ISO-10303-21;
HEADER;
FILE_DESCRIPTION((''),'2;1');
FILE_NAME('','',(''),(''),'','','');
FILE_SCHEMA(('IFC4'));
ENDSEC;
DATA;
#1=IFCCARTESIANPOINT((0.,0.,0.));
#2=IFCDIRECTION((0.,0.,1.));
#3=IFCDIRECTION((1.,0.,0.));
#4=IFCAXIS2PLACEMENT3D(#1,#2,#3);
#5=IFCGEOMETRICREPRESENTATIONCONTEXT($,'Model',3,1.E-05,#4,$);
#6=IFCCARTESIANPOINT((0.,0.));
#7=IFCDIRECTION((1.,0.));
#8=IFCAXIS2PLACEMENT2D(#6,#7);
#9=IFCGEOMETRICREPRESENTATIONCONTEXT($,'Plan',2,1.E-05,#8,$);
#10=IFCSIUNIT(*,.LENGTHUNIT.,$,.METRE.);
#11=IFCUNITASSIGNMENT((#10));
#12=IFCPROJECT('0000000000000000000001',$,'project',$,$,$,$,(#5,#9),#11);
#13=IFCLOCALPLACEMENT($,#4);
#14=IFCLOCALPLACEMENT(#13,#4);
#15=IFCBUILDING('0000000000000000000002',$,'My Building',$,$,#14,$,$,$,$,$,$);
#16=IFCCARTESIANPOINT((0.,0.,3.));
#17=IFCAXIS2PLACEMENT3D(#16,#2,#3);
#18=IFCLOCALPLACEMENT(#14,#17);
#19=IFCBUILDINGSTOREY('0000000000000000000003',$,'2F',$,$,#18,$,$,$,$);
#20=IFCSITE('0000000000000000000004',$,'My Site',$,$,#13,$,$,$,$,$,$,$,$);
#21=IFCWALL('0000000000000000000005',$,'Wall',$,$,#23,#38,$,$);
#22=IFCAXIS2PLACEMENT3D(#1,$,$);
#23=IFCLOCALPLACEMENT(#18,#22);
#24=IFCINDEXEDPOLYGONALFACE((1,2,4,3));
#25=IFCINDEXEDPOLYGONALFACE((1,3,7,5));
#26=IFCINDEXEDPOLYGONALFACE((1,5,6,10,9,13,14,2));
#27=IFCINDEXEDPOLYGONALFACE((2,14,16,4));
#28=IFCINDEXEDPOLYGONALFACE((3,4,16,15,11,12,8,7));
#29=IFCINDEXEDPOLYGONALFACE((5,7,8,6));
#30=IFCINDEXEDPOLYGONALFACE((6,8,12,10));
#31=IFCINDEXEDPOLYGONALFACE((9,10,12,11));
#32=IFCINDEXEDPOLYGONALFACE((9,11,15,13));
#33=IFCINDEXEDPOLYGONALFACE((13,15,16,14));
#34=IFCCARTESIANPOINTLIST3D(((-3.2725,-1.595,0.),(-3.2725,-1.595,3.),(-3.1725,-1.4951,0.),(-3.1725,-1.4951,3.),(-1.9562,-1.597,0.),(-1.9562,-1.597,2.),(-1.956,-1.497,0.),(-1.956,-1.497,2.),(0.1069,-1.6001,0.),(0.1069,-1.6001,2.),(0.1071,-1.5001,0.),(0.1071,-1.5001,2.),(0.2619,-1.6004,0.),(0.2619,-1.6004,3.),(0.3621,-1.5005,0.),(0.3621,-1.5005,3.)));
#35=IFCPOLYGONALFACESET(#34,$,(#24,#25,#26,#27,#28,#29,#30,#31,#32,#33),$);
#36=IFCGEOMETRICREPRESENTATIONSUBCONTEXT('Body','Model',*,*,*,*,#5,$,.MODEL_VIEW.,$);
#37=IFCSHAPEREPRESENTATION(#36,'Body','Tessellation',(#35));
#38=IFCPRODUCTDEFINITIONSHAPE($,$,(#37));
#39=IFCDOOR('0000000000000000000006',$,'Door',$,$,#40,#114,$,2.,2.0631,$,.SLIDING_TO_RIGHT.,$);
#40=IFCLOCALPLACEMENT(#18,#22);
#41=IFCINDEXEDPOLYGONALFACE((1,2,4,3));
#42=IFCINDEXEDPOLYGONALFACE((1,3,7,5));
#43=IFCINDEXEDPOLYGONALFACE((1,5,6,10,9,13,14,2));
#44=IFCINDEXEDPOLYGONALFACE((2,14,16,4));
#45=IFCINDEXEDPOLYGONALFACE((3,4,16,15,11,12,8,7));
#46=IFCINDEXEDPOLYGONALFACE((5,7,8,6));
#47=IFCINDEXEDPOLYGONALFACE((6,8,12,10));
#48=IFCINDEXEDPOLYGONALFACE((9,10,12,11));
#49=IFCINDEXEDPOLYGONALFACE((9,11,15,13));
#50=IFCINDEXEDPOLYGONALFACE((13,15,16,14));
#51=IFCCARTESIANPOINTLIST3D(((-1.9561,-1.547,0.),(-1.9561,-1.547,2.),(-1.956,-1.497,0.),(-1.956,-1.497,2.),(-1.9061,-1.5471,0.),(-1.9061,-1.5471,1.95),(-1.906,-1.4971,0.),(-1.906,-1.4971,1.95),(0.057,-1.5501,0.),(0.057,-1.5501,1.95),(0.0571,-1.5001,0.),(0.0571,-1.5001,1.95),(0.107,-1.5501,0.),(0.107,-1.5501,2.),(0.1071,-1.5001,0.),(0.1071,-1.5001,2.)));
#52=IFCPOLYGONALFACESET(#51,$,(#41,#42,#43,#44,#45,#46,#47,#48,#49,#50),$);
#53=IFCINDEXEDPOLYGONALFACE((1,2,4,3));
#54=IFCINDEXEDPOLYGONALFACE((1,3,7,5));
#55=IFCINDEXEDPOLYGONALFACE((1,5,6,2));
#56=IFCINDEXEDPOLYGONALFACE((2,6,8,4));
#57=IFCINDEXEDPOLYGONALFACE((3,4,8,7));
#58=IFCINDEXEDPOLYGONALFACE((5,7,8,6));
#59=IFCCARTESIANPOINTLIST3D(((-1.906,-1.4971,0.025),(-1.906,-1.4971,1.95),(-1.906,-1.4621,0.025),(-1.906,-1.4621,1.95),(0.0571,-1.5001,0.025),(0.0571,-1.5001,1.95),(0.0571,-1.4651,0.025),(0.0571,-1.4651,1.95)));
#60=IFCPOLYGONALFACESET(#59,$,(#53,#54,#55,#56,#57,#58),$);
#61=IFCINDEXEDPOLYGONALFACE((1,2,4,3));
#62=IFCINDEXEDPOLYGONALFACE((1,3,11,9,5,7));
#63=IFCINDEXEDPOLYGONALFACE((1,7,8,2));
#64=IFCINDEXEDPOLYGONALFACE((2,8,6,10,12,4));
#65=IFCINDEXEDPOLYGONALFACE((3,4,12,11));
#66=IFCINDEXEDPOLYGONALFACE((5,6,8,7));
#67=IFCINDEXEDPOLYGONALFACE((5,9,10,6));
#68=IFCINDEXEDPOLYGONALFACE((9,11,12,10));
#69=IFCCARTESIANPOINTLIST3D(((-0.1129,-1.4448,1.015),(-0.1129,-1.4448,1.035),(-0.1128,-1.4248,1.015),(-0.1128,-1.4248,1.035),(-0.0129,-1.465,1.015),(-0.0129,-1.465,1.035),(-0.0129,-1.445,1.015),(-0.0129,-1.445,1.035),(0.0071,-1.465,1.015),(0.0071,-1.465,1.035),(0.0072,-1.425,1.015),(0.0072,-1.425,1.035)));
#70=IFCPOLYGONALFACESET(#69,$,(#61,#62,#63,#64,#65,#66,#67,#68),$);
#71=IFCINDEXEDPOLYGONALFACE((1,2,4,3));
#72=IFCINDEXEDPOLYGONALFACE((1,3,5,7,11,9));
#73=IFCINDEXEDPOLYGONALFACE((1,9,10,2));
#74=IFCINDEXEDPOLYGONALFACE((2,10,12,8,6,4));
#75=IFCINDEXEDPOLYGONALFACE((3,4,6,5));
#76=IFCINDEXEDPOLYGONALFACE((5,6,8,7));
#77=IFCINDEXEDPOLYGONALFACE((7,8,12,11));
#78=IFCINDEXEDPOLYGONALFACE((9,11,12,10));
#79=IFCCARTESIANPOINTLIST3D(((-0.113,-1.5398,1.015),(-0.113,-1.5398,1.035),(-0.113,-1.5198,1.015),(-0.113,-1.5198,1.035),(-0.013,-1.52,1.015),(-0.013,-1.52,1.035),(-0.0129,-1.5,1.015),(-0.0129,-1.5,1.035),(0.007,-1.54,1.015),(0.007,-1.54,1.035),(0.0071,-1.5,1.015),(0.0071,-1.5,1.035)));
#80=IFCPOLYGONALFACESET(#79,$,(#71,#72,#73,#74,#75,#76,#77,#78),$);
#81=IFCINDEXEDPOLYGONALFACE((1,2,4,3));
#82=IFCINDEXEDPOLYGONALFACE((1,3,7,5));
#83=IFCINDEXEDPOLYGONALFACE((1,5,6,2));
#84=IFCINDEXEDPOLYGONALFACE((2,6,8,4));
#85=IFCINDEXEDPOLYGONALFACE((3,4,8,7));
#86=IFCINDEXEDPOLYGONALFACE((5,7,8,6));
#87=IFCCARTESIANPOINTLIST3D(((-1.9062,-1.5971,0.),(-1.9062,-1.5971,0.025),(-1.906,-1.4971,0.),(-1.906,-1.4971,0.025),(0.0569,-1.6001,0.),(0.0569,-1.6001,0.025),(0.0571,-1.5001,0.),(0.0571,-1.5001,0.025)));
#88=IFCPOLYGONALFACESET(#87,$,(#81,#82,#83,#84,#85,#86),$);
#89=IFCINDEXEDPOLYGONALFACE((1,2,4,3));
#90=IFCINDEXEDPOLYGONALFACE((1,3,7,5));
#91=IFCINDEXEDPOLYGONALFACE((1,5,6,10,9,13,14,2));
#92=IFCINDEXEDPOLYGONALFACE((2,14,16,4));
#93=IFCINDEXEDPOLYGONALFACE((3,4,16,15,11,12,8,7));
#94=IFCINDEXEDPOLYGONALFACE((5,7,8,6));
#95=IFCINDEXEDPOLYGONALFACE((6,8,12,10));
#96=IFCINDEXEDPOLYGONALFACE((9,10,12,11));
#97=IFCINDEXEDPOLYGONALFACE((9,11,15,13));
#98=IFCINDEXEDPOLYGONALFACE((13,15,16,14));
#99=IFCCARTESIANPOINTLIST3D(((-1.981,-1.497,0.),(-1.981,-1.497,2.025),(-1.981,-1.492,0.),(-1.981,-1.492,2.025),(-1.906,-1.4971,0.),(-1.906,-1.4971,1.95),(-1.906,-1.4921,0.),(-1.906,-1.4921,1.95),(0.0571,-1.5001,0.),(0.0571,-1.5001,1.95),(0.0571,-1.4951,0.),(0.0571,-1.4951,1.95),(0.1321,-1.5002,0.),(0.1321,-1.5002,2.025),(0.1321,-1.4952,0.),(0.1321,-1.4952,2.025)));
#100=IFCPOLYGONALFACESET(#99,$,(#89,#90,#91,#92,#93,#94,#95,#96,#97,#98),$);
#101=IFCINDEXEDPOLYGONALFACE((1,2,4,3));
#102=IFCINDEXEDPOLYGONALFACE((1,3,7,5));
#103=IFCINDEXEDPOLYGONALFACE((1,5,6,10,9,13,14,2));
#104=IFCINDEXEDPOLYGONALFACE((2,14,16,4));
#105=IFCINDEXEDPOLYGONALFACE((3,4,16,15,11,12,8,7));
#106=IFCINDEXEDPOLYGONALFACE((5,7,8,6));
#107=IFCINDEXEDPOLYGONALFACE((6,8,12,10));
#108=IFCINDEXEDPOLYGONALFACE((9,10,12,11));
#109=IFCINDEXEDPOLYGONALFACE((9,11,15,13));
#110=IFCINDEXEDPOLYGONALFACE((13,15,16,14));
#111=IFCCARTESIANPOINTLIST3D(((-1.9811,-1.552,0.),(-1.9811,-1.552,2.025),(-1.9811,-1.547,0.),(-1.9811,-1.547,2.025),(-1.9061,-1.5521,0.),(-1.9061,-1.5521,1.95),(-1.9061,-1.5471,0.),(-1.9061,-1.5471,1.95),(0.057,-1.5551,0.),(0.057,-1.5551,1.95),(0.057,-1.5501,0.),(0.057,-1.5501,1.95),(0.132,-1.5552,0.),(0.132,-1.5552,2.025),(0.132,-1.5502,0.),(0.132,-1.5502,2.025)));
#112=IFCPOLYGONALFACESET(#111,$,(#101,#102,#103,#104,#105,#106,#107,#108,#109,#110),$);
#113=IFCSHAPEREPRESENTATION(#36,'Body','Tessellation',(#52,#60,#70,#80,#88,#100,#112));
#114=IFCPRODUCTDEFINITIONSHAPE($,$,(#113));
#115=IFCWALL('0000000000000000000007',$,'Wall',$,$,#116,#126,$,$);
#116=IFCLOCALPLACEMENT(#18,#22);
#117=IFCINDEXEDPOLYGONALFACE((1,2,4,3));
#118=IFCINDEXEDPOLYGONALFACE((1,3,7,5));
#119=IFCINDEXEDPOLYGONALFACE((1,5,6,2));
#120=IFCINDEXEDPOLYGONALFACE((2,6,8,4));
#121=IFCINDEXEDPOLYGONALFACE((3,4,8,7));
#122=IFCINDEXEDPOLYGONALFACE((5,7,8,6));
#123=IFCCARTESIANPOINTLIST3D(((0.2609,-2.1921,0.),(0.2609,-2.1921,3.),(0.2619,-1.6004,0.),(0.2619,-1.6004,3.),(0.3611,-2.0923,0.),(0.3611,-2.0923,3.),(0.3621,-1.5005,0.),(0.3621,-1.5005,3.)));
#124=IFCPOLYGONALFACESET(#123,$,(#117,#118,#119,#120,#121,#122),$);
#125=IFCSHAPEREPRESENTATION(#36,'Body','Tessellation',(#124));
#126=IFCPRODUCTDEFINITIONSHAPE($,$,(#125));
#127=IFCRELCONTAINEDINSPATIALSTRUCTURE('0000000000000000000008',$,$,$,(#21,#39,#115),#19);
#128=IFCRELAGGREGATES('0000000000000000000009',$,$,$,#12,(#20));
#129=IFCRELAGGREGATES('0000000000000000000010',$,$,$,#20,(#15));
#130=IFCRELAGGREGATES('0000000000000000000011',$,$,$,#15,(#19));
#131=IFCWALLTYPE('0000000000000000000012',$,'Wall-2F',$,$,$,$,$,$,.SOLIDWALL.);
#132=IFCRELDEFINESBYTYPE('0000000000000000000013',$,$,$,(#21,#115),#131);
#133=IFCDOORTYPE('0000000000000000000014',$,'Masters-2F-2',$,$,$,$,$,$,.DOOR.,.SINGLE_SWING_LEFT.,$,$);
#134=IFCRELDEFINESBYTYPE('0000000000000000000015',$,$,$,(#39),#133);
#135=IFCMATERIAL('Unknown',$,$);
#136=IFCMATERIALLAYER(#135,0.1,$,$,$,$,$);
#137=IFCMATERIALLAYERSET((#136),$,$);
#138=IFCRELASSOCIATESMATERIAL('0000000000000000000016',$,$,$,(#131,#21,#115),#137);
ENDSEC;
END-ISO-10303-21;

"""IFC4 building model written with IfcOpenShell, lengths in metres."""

from ifc_helpers import new_model, entity, si_unit, frame, origin_with_axes, origin_2d_with_axis, place, context, subcontext, project, spatial, line, indexed_curve, outline, extrude, shape, source, transform, mapped, material, layer, layer_set, layer_usage, type_object, type_shapes, element, fill, save


model = new_model("IFC4")

# Units and contexts
model_context = context("Model", 3, precision=1e-05, world=origin_with_axes())
plan_context = context("Plan", 2, precision=1e-05, world=origin_2d_with_axis())
body_context_1 = subcontext(model_context, "Body", "Model", "MODEL_VIEW")
body_context_2 = subcontext(plan_context, "Body", "Plan", "PLAN_VIEW")
ifc_project = project(units=[si_unit("LENGTHUNIT", "METRE")], contexts=[model_context, plan_context])

# Site, building, storey
site_placement = place(None, origin_with_axes())
site = spatial("IfcSite", under=ifc_project, at=site_placement, Name="My Site")
building_placement = place(site_placement, origin_with_axes())
building = spatial("IfcBuilding", under=site, at=building_placement, Name="My Building")
storey_placement = place(building_placement, frame((0.0, 0.0, 3.0), z_axis=(0.0, 0.0, 1.0), x_axis=(1.0, 0.0, 0.0)))
storey = spatial("IfcBuildingStorey", under=building, at=storey_placement, Name="2F")

# Shared definitions
ifc_material = material(Name="Unknown")

# Wall, opening, door
ifc_layer_1 = layer(ifc_material, 0.1)
ifc_layer_set_1 = layer_set([ifc_layer_1])
ifc_layer_usage_1 = layer_usage(ifc_layer_set_1, "AXIS2", "POSITIVE", 0.0)
wall_type = type_object("IfcWallType", Name="Wall-2F", PredefinedType="SOLIDWALL", material=ifc_layer_set_1)
wall_1_placement = place(storey_placement, frame((-3.2725, -1.595, 0.0), z_axis=(0.0, 0.0, 1.0), x_axis=(0.999999, -0.001525, 0.0)))
wall_1 = element("IfcWall", 1, at=wall_1_placement, inside=storey, type_object=wall_type, material=ifc_layer_usage_1, Name="Wall", context=body_context_1, shape_type="SweptSolid", body=[
    extrude(outline(indexed_curve([(0.0, 0.0), (0.0998, 0.1), (3.6345, 0.1), (3.5345, 0.0)], segments=[line(1, 2, 3, 4, 1)])), origin_with_axes(), (0.0, 0.0, 1.0), 3.0),
])
shared_shape_1 = source(origin_with_axes(), body_context_1, "Body", "SweptSolid", [
    extrude(outline(indexed_curve([(0.0, 0.0), (2.0631, 0.0), (2.0631, 2.0), (0.0, 2.0)], segments=[line(1, 2, 3, 4, 1)])), frame((0.0, -0.6, 0.0), z_axis=(0.0, -1.0, 0.0), x_axis=(1.0, 0.0, 0.0)), (0.0, 0.0, -1.0), 1.2),
])
opening_1_placement = place(wall_1_placement, frame((3.3794, 0.1, 0.0), z_axis=(0.0, 0.0, 1.0), x_axis=(-1.0, 0.0, 0.0)))
opening_1 = element("IfcOpeningElement", 2, at=opening_1_placement, cuts=wall_1, PredefinedType="OPENING", context=body_context_1, shape_type="MappedRepresentation", body=[
    mapped(shared_shape_1, transform((0.0, 0.0, 0.0), x_axis=(1.0, 0.0, 0.0), y_axis=(0.0, 1.0, 0.0), z_axis=(0.0, 0.0, 1.0), scale=1.0)),
])
door_type_1 = type_object("IfcDoorType", Name="Masters-2F-2", OperationType="SINGLE_SWING_LEFT", PredefinedType="DOOR")
shared_shape_2 = source(origin_with_axes(), body_context_1, "Body", "SweptSolid", [
    extrude(outline(indexed_curve([(0.0, 0.0), (0.0, 2.0), (2.0631, 2.0), (2.0631, 0.0), (2.0131, 0.0), (2.0131, 1.95), (0.05, 1.95), (0.05, 0.0)], segments=[line(1, 2, 3, 4, 5, 6, 7, 8, 1)])), frame((0.0, 0.0, 0.0), z_axis=(0.0, -1.0, 0.0), x_axis=(1.0, 0.0, 0.0)), (0.0, 0.0, -1.0), 0.05),
    extrude(outline(indexed_curve([(0.0, 0.0), (1.9631, 0.0), (1.9631, 0.035), (0.0, 0.035)], segments=[line(1, 2, 3, 4, 1)])), frame((0.05, -0.035, 0.025), z_axis=(0.0, 0.0, 1.0), x_axis=(1.0, 0.0, 0.0)), (0.0, 0.0, 1.0), 1.925),
    extrude(outline(indexed_curve([(0.0, 0.0), (0.0, -0.04), (0.12, -0.04), (0.12, -0.02), (0.02, -0.02), (0.02, 0.0)], segments=[line(1, 2, 3, 4, 5, 6, 1)])), frame((0.1, -0.035, 1.015), z_axis=(0.0, 0.0, 1.0), x_axis=(1.0, 0.0, 0.0)), (0.0, 0.0, 1.0), 0.02),
    extrude(outline(indexed_curve([(0.0, 0.0), (0.0, 0.04), (0.12, 0.04), (0.12, 0.02), (0.02, 0.02), (0.02, 0.0)], segments=[line(1, 2, 3, 4, 5, 6, 1)])), frame((0.1, 0.0, 1.015), z_axis=(0.0, 0.0, 1.0), x_axis=(1.0, 0.0, 0.0)), (0.0, 0.0, 1.0), 0.02),
    extrude(outline(indexed_curve([(0.0, 0.0), (1.9631, 0.0), (1.9631, 0.1), (0.0, 0.1)], segments=[line(1, 2, 3, 4, 1)])), frame((0.05, 0.0, 0.0), z_axis=(0.0, 0.0, 1.0), x_axis=(1.0, 0.0, 0.0)), (0.0, 0.0, 1.0), 0.025),
    extrude(outline(indexed_curve([(0.0, 0.0), (0.0, 2.025), (2.1131, 2.025), (2.1131, 0.0), (2.0381, 0.0), (2.0381, 1.95), (0.075, 1.95), (0.075, 0.0)], segments=[line(1, 2, 3, 4, 5, 6, 7, 8, 1)])), frame((-0.025, -0.005, 0.0), z_axis=(0.0, -1.0, 0.0), x_axis=(1.0, 0.0, 0.0)), (0.0, 0.0, -1.0), 0.005),
    extrude(outline(indexed_curve([(0.0, 0.0), (0.0, 2.025), (2.1131, 2.025), (2.1131, 0.0), (2.0381, 0.0), (2.0381, 1.95), (0.075, 1.95), (0.075, 0.0)], segments=[line(1, 2, 3, 4, 5, 6, 7, 8, 1)])), frame((-0.025, 0.05, 0.0), z_axis=(0.0, -1.0, 0.0), x_axis=(1.0, 0.0, 0.0)), (0.0, 0.0, -1.0), 0.005),
])
shared_shape_3 = source(origin_with_axes(), body_context_2, "Body", "Curve2D", [
    entity("IfcIndexedPolyCurve", entity("IfcCartesianPointList2D", [[0.0, 0.0], [0.05, 0.0], [0.05, 0.05], [0.0, 0.05]]), [entity("IfcLineIndex", [1, 2, 3, 4, 1])]),
    entity("IfcIndexedPolyCurve", entity("IfcCartesianPointList2D", [[2.0631, 0.0], [2.0131, 0.0], [2.0131, 0.05], [2.0631, 0.05]]), [entity("IfcLineIndex", [1, 2, 3, 4, 1])]),
    entity("IfcIndexedPolyCurve", entity("IfcCartesianPointList2D", [[2.9946, -0.035], [1.0315, -0.035], [1.0315, 0.0], [2.9946, 0.0]]), [entity("IfcLineIndex", [1, 2, 3, 4, 1])]),
])
type_shapes(door_type_1, [shared_shape_2, shared_shape_3])
door_1_placement = place(opening_1_placement, frame((0.0, 0.0, 0.0), z_axis=(0.0, 0.0, 1.0), x_axis=(1.0, 0.0, 0.0)))
door_1 = element("IfcDoor", 3, at=door_1_placement, inside=storey, type_object=door_type_1, Name="Door", OperationType="SLIDING_TO_RIGHT", OverallHeight=2.0, OverallWidth=2.0631, shapes=[
    shape(body_context_1, "Body", "MappedRepresentation", [mapped(shared_shape_2, transform((0.0, 0.0, 0.0), x_axis=(1.0, 0.0, 0.0), y_axis=(0.0, 1.0, 0.0), z_axis=(0.0, 0.0, 1.0), scale=1.0))]),
    shape(body_context_2, "Body", "MappedRepresentation", [mapped(shared_shape_3, transform((0.0, 0.0, 0.0), x_axis=(1.0, 0.0, 0.0), y_axis=(0.0, 1.0, 0.0), z_axis=(0.0, 0.0, 1.0), scale=1.0))]),
])
fill(opening_1, door_1)

# Wall
ifc_layer_usage_2 = layer_usage(ifc_layer_set_1, "AXIS2", "POSITIVE", 0.0)
wall_2_placement = place(storey_placement, frame((0.2619, -1.6004, 0.0), z_axis=(0.0, 0.0, 1.0), x_axis=(-0.001703, -0.999999, 0.0)))
element("IfcWall", 4, at=wall_2_placement, inside=storey, type_object=wall_type, material=ifc_layer_usage_2, Name="Wall", context=body_context_1, shape_type="SweptSolid", body=[
    extrude(outline(indexed_curve([(0.0, 0.0), (-0.1, 0.1), (0.4917, 0.1), (0.5917, 0.0)], segments=[line(1, 2, 3, 4, 1)])), origin_with_axes(), (0.0, 0.0, 1.0), 3.0),
])

save(model, "model.ifc")
